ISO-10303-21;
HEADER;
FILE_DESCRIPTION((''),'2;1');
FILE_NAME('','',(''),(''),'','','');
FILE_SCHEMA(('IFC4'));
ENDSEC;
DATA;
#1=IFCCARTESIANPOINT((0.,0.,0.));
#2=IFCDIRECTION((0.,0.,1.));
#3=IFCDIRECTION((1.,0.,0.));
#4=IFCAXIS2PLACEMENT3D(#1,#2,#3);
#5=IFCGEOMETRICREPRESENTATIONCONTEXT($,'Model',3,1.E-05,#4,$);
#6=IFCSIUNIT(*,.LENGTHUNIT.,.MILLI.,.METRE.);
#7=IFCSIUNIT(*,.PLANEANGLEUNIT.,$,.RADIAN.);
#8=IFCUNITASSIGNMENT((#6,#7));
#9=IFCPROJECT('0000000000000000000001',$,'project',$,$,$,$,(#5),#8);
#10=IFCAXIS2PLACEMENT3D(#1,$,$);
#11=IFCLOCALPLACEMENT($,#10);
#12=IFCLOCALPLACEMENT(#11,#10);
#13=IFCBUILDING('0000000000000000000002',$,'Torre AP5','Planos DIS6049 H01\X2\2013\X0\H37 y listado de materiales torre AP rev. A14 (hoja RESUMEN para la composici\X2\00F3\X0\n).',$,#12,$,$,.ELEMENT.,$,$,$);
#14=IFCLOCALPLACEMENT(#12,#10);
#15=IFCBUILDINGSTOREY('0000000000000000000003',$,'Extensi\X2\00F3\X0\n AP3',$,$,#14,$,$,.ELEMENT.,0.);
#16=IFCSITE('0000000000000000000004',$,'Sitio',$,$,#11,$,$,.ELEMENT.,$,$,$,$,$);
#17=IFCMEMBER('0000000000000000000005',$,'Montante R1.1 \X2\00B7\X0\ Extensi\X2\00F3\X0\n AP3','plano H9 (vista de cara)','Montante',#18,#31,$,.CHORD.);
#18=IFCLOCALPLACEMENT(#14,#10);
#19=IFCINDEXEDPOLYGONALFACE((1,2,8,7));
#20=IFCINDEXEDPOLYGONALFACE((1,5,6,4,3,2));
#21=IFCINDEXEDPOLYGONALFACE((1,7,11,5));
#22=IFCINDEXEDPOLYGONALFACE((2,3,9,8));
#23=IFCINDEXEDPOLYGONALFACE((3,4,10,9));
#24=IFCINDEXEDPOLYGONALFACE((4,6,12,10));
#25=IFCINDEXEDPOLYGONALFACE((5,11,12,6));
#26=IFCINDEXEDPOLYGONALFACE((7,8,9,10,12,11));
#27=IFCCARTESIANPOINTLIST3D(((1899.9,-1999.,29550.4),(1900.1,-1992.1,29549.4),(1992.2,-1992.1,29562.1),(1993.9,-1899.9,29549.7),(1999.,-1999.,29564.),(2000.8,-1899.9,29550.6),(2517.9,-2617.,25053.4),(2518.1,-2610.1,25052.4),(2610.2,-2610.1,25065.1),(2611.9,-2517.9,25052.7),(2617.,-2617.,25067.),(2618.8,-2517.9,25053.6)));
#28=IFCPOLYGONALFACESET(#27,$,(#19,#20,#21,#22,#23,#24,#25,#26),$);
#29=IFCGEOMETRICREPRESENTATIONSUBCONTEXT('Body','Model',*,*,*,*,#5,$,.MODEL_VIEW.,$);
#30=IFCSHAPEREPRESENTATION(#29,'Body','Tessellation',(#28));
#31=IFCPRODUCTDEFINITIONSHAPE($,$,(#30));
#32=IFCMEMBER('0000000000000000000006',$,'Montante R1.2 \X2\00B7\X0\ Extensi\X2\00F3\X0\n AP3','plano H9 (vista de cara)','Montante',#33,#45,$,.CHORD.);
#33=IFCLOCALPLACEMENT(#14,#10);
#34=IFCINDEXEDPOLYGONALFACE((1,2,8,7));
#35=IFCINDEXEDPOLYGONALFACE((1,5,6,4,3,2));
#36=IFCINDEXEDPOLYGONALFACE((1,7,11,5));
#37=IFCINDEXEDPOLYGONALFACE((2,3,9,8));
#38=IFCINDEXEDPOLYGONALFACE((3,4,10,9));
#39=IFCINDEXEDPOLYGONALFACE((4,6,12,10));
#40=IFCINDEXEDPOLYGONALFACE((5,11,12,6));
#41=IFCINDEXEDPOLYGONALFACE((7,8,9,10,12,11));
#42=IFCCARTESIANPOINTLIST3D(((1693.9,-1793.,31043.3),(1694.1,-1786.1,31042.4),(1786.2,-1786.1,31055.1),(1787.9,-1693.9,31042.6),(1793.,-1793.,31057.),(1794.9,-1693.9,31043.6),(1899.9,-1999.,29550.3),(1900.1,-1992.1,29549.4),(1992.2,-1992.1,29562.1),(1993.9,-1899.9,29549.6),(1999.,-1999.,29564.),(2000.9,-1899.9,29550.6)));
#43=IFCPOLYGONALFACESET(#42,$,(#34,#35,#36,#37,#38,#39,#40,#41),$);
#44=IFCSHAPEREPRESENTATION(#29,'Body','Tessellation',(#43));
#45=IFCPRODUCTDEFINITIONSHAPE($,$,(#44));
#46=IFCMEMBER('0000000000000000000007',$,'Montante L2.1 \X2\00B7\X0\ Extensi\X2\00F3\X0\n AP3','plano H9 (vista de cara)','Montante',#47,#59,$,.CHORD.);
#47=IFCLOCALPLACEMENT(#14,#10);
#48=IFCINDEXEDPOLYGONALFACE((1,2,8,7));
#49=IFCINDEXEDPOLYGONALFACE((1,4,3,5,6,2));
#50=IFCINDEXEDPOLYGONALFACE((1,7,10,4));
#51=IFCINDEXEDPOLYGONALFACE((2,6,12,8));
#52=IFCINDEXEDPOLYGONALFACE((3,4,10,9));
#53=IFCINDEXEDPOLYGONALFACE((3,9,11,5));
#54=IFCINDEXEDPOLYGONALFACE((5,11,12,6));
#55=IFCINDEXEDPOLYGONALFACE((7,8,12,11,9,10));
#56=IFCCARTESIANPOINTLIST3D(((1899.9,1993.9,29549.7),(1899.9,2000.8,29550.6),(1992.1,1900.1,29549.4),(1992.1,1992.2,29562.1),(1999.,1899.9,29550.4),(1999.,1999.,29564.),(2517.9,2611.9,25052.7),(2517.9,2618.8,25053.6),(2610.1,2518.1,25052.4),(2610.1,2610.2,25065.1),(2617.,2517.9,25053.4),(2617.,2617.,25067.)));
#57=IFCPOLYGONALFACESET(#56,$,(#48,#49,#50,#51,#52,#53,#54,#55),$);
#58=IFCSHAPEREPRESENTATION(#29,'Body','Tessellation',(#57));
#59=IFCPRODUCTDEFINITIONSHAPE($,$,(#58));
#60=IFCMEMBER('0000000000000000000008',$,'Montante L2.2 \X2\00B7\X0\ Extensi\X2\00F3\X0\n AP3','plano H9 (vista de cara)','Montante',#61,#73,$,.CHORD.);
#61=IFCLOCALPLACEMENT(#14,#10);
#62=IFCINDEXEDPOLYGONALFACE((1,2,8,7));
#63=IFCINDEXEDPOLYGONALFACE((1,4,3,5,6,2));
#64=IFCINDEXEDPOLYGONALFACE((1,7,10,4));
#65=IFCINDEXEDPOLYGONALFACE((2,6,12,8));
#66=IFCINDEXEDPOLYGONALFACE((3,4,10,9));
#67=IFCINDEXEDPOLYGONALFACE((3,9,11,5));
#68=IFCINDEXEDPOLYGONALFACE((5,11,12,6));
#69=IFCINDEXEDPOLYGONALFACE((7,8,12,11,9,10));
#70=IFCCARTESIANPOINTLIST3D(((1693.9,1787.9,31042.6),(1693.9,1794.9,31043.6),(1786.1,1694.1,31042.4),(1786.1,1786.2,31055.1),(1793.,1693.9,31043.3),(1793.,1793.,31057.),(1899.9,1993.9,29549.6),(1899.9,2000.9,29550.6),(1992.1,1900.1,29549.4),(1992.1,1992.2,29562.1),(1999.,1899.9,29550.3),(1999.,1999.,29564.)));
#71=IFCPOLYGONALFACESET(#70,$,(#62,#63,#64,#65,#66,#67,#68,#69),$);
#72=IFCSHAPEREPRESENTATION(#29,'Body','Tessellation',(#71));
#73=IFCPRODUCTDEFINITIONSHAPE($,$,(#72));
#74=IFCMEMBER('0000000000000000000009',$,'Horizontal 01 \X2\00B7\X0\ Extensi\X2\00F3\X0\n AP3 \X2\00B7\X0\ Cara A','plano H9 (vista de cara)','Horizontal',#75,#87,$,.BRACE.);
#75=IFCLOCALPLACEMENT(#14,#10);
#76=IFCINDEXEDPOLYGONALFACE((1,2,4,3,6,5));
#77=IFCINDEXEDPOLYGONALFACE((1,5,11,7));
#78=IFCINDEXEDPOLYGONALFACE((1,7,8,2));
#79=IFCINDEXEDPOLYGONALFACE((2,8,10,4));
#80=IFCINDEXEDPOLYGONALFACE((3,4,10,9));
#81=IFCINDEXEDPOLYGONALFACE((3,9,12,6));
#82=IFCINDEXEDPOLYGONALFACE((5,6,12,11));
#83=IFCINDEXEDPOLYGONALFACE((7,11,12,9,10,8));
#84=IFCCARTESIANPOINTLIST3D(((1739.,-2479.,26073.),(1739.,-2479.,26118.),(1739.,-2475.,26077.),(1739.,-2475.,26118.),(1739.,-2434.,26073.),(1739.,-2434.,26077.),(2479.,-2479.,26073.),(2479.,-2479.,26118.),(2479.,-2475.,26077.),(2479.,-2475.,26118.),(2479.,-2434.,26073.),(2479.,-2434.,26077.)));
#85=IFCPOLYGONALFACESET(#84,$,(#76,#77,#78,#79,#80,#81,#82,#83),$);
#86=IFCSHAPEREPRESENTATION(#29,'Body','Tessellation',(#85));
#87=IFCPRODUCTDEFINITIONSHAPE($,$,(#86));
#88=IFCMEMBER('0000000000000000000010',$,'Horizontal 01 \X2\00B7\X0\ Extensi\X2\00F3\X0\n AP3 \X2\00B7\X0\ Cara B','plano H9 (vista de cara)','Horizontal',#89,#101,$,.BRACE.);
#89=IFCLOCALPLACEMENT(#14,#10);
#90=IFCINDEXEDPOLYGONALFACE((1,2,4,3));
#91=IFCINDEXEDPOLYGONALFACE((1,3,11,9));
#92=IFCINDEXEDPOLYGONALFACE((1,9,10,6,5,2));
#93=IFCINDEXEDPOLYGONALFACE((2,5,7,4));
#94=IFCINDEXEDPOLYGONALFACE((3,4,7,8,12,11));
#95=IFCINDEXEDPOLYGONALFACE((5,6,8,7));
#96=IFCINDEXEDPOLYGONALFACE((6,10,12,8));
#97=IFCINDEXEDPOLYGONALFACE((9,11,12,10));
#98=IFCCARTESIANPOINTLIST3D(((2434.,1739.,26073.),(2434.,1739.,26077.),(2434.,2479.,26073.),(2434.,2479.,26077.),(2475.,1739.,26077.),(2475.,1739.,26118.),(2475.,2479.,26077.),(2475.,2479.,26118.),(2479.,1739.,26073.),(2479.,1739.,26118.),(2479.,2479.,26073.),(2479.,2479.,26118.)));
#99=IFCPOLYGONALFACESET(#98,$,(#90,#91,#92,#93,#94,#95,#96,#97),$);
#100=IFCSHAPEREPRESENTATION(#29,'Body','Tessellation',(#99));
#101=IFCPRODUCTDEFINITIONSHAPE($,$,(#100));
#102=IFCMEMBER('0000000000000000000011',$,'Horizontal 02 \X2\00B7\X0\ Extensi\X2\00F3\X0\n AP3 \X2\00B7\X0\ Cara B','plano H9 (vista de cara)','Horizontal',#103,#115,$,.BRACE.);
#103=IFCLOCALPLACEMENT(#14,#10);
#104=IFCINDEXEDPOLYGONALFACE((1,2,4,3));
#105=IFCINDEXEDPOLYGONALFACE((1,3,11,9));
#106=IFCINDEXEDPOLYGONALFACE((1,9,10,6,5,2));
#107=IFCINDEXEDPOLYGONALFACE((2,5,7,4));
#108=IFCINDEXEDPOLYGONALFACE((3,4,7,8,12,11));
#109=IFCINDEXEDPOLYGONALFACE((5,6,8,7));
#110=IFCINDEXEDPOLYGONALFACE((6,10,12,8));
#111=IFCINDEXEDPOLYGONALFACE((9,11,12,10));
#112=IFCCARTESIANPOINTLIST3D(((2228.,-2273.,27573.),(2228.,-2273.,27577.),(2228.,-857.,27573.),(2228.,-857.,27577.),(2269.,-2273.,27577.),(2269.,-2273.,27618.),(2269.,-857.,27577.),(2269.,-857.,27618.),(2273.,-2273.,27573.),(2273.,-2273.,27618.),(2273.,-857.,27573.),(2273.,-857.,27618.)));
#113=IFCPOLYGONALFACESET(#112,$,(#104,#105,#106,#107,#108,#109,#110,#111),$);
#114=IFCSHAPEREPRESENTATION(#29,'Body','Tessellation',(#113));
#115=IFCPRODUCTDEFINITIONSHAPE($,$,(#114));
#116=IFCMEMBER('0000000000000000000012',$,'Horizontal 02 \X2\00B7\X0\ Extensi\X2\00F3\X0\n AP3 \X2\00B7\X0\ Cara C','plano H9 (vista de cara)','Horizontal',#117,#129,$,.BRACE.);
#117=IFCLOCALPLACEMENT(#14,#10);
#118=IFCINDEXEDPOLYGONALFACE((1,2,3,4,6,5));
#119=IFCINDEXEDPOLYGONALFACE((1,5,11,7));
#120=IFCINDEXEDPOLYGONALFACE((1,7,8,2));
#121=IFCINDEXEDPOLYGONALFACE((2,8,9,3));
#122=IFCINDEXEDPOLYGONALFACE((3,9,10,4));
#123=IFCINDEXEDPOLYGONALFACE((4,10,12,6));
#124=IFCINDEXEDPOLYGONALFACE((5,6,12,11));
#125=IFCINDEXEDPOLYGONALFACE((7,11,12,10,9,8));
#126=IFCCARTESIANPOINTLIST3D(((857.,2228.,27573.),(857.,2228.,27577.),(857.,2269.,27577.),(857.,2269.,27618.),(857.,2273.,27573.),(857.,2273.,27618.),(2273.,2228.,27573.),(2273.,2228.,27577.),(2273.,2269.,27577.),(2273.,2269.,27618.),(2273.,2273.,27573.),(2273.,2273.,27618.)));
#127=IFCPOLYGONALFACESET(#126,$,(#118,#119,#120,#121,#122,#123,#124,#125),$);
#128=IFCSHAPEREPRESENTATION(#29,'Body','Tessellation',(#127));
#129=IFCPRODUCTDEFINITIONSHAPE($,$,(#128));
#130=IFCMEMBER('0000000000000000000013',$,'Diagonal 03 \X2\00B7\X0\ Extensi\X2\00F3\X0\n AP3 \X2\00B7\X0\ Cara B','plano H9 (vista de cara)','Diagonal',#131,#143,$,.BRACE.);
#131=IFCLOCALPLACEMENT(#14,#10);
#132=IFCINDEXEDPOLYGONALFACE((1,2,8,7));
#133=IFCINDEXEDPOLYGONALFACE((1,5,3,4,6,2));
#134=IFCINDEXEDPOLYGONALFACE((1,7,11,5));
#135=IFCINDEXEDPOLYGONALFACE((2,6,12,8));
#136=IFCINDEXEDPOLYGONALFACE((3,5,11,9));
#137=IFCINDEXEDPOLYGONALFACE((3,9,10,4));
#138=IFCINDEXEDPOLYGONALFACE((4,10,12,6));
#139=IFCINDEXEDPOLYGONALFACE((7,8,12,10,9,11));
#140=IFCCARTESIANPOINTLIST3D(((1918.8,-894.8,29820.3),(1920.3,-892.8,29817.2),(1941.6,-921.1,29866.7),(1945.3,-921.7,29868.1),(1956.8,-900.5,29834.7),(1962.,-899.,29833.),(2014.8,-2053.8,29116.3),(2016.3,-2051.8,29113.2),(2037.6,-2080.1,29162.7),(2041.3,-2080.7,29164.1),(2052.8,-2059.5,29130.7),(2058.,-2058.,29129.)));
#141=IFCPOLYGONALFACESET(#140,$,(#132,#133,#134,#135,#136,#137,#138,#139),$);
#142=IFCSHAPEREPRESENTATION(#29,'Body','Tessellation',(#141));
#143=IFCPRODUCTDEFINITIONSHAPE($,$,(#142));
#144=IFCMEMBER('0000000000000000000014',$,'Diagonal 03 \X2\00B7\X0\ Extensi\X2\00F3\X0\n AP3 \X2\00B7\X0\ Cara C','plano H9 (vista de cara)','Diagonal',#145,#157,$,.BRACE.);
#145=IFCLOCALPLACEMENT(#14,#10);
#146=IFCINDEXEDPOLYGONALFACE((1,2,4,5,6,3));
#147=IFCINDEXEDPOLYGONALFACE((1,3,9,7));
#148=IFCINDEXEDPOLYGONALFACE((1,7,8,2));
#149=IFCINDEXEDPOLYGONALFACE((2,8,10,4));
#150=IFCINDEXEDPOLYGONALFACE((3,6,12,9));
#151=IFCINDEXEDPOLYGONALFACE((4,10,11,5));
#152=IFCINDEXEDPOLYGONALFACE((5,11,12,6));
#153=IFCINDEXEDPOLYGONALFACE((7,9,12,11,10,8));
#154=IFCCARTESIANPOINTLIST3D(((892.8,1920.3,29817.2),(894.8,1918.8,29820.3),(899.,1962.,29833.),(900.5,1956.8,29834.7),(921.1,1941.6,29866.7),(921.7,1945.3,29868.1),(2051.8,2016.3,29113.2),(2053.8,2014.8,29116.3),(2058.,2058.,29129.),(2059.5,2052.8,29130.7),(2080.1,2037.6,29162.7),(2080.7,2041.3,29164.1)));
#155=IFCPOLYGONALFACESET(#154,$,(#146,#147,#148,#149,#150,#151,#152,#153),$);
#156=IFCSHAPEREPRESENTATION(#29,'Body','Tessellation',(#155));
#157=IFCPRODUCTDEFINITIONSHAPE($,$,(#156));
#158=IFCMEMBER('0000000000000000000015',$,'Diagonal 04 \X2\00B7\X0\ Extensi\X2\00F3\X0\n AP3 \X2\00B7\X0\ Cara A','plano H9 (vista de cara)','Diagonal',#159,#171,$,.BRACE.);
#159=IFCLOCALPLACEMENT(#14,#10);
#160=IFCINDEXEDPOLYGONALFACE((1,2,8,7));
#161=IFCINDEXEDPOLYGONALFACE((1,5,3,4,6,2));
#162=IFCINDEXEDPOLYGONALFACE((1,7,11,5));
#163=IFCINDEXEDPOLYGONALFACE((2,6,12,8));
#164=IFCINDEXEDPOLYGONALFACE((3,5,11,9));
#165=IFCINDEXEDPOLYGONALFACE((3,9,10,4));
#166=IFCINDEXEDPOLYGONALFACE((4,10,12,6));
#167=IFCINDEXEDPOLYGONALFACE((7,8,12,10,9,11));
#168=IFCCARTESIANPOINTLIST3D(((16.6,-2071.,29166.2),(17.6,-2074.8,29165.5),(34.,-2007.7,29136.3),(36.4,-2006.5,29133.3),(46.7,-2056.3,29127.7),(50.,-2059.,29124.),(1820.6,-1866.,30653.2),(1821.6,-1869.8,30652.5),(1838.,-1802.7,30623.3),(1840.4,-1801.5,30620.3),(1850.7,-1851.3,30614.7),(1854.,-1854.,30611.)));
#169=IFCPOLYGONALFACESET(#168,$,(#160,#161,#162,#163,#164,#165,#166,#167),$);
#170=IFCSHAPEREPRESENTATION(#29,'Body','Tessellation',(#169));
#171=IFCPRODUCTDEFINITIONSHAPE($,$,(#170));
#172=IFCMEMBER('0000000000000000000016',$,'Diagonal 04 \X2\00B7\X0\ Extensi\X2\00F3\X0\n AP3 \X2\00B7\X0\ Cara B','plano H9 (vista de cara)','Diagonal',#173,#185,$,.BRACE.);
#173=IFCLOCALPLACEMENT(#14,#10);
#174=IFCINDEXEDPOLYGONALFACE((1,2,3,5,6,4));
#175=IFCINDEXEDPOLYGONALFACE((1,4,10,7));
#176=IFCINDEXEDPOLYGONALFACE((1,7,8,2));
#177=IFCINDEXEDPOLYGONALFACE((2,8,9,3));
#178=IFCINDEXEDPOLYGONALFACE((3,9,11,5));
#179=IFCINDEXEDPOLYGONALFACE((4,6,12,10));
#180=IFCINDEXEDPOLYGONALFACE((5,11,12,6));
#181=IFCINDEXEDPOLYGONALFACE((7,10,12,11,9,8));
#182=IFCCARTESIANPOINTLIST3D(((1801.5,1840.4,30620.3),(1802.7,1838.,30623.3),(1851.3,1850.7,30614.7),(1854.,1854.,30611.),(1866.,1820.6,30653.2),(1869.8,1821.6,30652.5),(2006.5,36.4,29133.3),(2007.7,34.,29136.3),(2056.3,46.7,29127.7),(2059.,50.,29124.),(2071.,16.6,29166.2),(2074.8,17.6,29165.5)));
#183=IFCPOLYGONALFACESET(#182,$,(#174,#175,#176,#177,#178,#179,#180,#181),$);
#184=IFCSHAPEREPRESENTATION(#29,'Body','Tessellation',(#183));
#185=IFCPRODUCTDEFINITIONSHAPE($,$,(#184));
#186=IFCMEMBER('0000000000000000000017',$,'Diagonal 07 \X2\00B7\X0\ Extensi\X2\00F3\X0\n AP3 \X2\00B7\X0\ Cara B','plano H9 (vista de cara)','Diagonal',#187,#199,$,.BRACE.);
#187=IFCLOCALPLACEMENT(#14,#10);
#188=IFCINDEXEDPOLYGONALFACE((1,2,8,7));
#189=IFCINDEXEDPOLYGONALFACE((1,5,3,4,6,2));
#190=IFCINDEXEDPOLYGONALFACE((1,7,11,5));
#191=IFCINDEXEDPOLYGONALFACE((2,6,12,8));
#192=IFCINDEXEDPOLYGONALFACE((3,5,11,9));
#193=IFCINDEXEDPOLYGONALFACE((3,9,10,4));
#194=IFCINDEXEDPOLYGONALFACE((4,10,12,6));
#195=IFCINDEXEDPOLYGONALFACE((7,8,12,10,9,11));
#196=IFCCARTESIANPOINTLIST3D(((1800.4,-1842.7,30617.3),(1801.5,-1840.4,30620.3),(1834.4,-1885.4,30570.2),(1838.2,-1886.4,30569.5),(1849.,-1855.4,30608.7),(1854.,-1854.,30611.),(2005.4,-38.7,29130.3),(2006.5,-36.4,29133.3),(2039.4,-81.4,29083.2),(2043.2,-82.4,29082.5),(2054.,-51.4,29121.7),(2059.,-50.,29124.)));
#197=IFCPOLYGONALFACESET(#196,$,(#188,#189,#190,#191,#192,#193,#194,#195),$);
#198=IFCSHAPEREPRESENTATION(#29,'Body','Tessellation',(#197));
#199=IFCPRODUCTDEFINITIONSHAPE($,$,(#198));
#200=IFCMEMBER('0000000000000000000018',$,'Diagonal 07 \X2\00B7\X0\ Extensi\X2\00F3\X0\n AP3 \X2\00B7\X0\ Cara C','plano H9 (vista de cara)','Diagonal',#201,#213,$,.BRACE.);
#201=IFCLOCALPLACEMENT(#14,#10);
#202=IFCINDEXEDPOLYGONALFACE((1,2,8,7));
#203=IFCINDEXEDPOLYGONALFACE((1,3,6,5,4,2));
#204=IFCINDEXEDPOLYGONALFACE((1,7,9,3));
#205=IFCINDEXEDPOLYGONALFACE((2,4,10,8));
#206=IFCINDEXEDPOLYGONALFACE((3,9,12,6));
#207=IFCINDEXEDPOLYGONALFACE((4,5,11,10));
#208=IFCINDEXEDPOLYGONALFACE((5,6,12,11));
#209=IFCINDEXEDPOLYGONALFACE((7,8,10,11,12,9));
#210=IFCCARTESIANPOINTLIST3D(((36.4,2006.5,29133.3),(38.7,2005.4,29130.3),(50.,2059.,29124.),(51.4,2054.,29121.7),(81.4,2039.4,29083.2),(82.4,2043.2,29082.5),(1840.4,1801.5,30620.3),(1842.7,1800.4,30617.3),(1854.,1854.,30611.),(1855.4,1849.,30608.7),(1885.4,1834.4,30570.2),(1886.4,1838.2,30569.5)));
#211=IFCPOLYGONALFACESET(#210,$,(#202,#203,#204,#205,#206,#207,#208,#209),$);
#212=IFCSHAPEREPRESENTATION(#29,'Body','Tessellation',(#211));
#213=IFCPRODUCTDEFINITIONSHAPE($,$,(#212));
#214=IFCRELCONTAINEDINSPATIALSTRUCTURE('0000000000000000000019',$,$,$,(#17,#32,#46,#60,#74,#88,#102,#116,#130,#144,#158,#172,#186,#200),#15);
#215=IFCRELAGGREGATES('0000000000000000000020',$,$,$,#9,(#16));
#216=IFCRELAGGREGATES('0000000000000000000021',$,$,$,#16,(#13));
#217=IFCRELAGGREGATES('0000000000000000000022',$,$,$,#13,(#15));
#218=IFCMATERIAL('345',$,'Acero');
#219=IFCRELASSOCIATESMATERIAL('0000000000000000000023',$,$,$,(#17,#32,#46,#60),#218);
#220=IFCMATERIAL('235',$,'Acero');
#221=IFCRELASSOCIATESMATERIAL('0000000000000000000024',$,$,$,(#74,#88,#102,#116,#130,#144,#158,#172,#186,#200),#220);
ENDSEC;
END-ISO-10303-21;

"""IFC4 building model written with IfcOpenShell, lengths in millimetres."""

from ifc_helpers import new_model, si_unit, frame, frame_2d, origin, origin_with_axes, place, context, subcontext, project, spatial, l_section, extrude, material, element, save


model = new_model("IFC4")

# Units and contexts
model_context = context("Model", 3, precision=1e-05, world=origin_with_axes())
body_context = subcontext(model_context, "Body", "Model", "MODEL_VIEW")
ifc_project = project(units=[si_unit("LENGTHUNIT", "METRE", prefix="MILLI"), si_unit("PLANEANGLEUNIT", "RADIAN")], contexts=[model_context])

# Site, building, storey
site_placement = place(None, origin())
site = spatial("IfcSite", under=ifc_project, at=site_placement, Name="Sitio", CompositionType="ELEMENT")
building_placement = place(site_placement, origin())
building = spatial("IfcBuilding", under=site, at=building_placement, Name="Torre AP5", Description="Planos DIS6049 H01–H37 y listado de materiales torre AP rev. A14 (hoja RESUMEN para la composición).", CompositionType="ELEMENT")
storey_placement = place(building_placement, origin())
storey = spatial("IfcBuildingStorey", under=building, at=storey_placement, Name="Extensión AP3", CompositionType="ELEMENT", Elevation=0.0)

# Members
ifc_material_1 = material(Name="345", Category="Acero")
member_1_placement = place(storey_placement, frame((2617.0, -2617.0, 25067.0), z_axis=(-0.134901, 0.134901, 0.981633), x_axis=(0.018366, 0.990859, -0.133645)))
element("IfcMember", 1, at=member_1_placement, inside=storey, material=ifc_material_1, Name="Montante R1.1 · Extensión AP3", Description="plano H9 (vista de cara)", ObjectType="Montante", PredefinedType="CHORD", context=body_context, shape_type="SweptSolid", body=[
    extrude(l_section(Depth=100.0, Width=100.0, Thickness=7.0, at=frame_2d((50.0, 50.0))), None, (0.0, 0.0, 1.0), 4581.1),
])
member_2_placement = place(storey_placement, frame((1999.0, -1999.0, 29564.0), z_axis=(-0.135423, 0.135423, 0.981489), x_axis=(0.01851, 0.990788, -0.134152)))
element("IfcMember", 2, at=member_2_placement, inside=storey, material=ifc_material_1, Name="Montante R1.2 · Extensión AP3", Description="plano H9 (vista de cara)", ObjectType="Montante", PredefinedType="CHORD", context=body_context, shape_type="SweptSolid", body=[
    extrude(l_section(Depth=100.0, Width=100.0, Thickness=7.0, at=frame_2d((50.0, 50.0))), None, (0.0, 0.0, 1.0), 1521.2),
])
member_3_placement = place(storey_placement, frame((2617.0, 2617.0, 25067.0), z_axis=(-0.134901, -0.134901, 0.981633), x_axis=(-0.990859, 0.018366, -0.133645)))
element("IfcMember", 3, at=member_3_placement, inside=storey, material=ifc_material_1, Name="Montante L2.1 · Extensión AP3", Description="plano H9 (vista de cara)", ObjectType="Montante", PredefinedType="CHORD", context=body_context, shape_type="SweptSolid", body=[
    extrude(l_section(Depth=100.0, Width=100.0, Thickness=7.0, at=frame_2d((50.0, 50.0))), None, (0.0, 0.0, 1.0), 4581.1),
])
member_4_placement = place(storey_placement, frame((1999.0, 1999.0, 29564.0), z_axis=(-0.135423, -0.135423, 0.981489), x_axis=(-0.990788, 0.01851, -0.134152)))
element("IfcMember", 4, at=member_4_placement, inside=storey, material=ifc_material_1, Name="Montante L2.2 · Extensión AP3", Description="plano H9 (vista de cara)", ObjectType="Montante", PredefinedType="CHORD", context=body_context, shape_type="SweptSolid", body=[
    extrude(l_section(Depth=100.0, Width=100.0, Thickness=7.0, at=frame_2d((50.0, 50.0))), None, (0.0, 0.0, 1.0), 1521.2),
])
ifc_material_2 = material(Name="235", Category="Acero")
for number, where, z_axis, x_axis, name in (
    (5, (1739.0, -2479.0, 26073.0), (1.0, 0.0, 0.0), (0.0, 1.0, 0.0), "Horizontal 01 · Extensión AP3 · Cara A"),
    (6, (2479.0, 1739.0, 26073.0), (0.0, 1.0, 0.0), (-1.0, 0.0, 0.0), "Horizontal 01 · Extensión AP3 · Cara B"),
):
    element("IfcMember", number, at=place(storey_placement, frame(where, z_axis=z_axis, x_axis=x_axis)), inside=storey, material=ifc_material_2, Name=name, Description="plano H9 (vista de cara)", ObjectType="Horizontal", PredefinedType="BRACE", context=body_context, shape_type="SweptSolid", body=[
        extrude(l_section(Depth=45.0, Width=45.0, Thickness=4.0, at=frame_2d((22.5, 22.5))), None, (0.0, 0.0, 1.0), 740.0),
    ])
for number, where, z_axis, x_axis, name in (
    (7, (2273.0, -2273.0, 27573.0), (0.0, 1.0, 0.0), (-1.0, 0.0, 0.0), "Horizontal 02 · Extensión AP3 · Cara B"),
    (8, (2273.0, 2273.0, 27573.0), (-1.0, 0.0, 0.0), (0.0, -1.0, 0.0), "Horizontal 02 · Extensión AP3 · Cara C"),
):
    element("IfcMember", number, at=place(storey_placement, frame(where, z_axis=z_axis, x_axis=x_axis)), inside=storey, material=ifc_material_2, Name=name, Description="plano H9 (vista de cara)", ObjectType="Horizontal", PredefinedType="BRACE", context=body_context, shape_type="SweptSolid", body=[
        extrude(l_section(Depth=45.0, Width=45.0, Thickness=4.0, at=frame_2d((22.5, 22.5))), None, (0.0, 0.0, 1.0), 1416.0),
    ])
for number, where, z_axis, x_axis, name in (
    (9, (2058.0, -2058.0, 29129.0), (-0.070617, 0.852549, 0.517855), (-0.925948, 0.137057, -0.351904), "Diagonal 03 · Extensión AP3 · Cara B"),
    (10, (2058.0, 2058.0, 29129.0), (-0.852549, -0.070617, 0.517855), (-0.137057, -0.925948, -0.351904), "Diagonal 03 · Extensión AP3 · Cara C"),
):
    element("IfcMember", number, at=place(storey_placement, frame(where, z_axis=z_axis, x_axis=x_axis)), inside=storey, material=ifc_material_2, Name=name, Description="plano H9 (vista de cara)", ObjectType="Diagonal", PredefinedType="BRACE", context=body_context, shape_type="SweptSolid", body=[
        extrude(l_section(Depth=45.0, Width=45.0, Thickness=4.0, at=frame_2d((22.5, 22.5))), None, (0.0, 0.0, 1.0), 1359.5),
    ])
for number, where, z_axis, x_axis, name in (
    (11, (50.0, -2059.0, 29124.0), (0.768697, 0.087352, 0.633621), (-0.247751, 0.953961, 0.169052), "Diagonal 04 · Extensión AP3 · Cara A"),
    (12, (2059.0, 50.0, 29124.0), (-0.087352, 0.768697, 0.633621), (-0.953961, -0.247751, 0.169052), "Diagonal 04 · Extensión AP3 · Cara B"),
):
    element("IfcMember", number, at=place(storey_placement, frame(where, z_axis=z_axis, x_axis=x_axis)), inside=storey, material=ifc_material_2, Name=name, Description="plano H9 (vista de cara)", ObjectType="Diagonal", PredefinedType="BRACE", context=body_context, shape_type="SweptSolid", body=[
        extrude(l_section(Depth=55.0, Width=55.0, Thickness=4.0, at=frame_2d((27.5, 27.5))), None, (0.0, 0.0, 1.0), 2346.8),
    ])
for number, where, z_axis, x_axis, name in (
    (13, (2059.0, -50.0, 29124.0), (-0.087352, -0.768697, 0.633621), (-0.953961, 0.247751, 0.169052), "Diagonal 07 · Extensión AP3 · Cara B"),
    (14, (50.0, 2059.0, 29124.0), (0.768697, -0.087352, 0.633621), (-0.247751, -0.953961, 0.169052), "Diagonal 07 · Extensión AP3 · Cara C"),
):
    element("IfcMember", number, at=place(storey_placement, frame(where, z_axis=z_axis, x_axis=x_axis)), inside=storey, material=ifc_material_2, Name=name, Description="plano H9 (vista de cara)", ObjectType="Diagonal", PredefinedType="BRACE", context=body_context, shape_type="SweptSolid", body=[
        extrude(l_section(Depth=55.0, Width=55.0, Thickness=4.0, at=frame_2d((27.5, 27.5))), None, (0.0, 0.0, 1.0), 2346.8),
    ])

save(model, "model.ifc")
